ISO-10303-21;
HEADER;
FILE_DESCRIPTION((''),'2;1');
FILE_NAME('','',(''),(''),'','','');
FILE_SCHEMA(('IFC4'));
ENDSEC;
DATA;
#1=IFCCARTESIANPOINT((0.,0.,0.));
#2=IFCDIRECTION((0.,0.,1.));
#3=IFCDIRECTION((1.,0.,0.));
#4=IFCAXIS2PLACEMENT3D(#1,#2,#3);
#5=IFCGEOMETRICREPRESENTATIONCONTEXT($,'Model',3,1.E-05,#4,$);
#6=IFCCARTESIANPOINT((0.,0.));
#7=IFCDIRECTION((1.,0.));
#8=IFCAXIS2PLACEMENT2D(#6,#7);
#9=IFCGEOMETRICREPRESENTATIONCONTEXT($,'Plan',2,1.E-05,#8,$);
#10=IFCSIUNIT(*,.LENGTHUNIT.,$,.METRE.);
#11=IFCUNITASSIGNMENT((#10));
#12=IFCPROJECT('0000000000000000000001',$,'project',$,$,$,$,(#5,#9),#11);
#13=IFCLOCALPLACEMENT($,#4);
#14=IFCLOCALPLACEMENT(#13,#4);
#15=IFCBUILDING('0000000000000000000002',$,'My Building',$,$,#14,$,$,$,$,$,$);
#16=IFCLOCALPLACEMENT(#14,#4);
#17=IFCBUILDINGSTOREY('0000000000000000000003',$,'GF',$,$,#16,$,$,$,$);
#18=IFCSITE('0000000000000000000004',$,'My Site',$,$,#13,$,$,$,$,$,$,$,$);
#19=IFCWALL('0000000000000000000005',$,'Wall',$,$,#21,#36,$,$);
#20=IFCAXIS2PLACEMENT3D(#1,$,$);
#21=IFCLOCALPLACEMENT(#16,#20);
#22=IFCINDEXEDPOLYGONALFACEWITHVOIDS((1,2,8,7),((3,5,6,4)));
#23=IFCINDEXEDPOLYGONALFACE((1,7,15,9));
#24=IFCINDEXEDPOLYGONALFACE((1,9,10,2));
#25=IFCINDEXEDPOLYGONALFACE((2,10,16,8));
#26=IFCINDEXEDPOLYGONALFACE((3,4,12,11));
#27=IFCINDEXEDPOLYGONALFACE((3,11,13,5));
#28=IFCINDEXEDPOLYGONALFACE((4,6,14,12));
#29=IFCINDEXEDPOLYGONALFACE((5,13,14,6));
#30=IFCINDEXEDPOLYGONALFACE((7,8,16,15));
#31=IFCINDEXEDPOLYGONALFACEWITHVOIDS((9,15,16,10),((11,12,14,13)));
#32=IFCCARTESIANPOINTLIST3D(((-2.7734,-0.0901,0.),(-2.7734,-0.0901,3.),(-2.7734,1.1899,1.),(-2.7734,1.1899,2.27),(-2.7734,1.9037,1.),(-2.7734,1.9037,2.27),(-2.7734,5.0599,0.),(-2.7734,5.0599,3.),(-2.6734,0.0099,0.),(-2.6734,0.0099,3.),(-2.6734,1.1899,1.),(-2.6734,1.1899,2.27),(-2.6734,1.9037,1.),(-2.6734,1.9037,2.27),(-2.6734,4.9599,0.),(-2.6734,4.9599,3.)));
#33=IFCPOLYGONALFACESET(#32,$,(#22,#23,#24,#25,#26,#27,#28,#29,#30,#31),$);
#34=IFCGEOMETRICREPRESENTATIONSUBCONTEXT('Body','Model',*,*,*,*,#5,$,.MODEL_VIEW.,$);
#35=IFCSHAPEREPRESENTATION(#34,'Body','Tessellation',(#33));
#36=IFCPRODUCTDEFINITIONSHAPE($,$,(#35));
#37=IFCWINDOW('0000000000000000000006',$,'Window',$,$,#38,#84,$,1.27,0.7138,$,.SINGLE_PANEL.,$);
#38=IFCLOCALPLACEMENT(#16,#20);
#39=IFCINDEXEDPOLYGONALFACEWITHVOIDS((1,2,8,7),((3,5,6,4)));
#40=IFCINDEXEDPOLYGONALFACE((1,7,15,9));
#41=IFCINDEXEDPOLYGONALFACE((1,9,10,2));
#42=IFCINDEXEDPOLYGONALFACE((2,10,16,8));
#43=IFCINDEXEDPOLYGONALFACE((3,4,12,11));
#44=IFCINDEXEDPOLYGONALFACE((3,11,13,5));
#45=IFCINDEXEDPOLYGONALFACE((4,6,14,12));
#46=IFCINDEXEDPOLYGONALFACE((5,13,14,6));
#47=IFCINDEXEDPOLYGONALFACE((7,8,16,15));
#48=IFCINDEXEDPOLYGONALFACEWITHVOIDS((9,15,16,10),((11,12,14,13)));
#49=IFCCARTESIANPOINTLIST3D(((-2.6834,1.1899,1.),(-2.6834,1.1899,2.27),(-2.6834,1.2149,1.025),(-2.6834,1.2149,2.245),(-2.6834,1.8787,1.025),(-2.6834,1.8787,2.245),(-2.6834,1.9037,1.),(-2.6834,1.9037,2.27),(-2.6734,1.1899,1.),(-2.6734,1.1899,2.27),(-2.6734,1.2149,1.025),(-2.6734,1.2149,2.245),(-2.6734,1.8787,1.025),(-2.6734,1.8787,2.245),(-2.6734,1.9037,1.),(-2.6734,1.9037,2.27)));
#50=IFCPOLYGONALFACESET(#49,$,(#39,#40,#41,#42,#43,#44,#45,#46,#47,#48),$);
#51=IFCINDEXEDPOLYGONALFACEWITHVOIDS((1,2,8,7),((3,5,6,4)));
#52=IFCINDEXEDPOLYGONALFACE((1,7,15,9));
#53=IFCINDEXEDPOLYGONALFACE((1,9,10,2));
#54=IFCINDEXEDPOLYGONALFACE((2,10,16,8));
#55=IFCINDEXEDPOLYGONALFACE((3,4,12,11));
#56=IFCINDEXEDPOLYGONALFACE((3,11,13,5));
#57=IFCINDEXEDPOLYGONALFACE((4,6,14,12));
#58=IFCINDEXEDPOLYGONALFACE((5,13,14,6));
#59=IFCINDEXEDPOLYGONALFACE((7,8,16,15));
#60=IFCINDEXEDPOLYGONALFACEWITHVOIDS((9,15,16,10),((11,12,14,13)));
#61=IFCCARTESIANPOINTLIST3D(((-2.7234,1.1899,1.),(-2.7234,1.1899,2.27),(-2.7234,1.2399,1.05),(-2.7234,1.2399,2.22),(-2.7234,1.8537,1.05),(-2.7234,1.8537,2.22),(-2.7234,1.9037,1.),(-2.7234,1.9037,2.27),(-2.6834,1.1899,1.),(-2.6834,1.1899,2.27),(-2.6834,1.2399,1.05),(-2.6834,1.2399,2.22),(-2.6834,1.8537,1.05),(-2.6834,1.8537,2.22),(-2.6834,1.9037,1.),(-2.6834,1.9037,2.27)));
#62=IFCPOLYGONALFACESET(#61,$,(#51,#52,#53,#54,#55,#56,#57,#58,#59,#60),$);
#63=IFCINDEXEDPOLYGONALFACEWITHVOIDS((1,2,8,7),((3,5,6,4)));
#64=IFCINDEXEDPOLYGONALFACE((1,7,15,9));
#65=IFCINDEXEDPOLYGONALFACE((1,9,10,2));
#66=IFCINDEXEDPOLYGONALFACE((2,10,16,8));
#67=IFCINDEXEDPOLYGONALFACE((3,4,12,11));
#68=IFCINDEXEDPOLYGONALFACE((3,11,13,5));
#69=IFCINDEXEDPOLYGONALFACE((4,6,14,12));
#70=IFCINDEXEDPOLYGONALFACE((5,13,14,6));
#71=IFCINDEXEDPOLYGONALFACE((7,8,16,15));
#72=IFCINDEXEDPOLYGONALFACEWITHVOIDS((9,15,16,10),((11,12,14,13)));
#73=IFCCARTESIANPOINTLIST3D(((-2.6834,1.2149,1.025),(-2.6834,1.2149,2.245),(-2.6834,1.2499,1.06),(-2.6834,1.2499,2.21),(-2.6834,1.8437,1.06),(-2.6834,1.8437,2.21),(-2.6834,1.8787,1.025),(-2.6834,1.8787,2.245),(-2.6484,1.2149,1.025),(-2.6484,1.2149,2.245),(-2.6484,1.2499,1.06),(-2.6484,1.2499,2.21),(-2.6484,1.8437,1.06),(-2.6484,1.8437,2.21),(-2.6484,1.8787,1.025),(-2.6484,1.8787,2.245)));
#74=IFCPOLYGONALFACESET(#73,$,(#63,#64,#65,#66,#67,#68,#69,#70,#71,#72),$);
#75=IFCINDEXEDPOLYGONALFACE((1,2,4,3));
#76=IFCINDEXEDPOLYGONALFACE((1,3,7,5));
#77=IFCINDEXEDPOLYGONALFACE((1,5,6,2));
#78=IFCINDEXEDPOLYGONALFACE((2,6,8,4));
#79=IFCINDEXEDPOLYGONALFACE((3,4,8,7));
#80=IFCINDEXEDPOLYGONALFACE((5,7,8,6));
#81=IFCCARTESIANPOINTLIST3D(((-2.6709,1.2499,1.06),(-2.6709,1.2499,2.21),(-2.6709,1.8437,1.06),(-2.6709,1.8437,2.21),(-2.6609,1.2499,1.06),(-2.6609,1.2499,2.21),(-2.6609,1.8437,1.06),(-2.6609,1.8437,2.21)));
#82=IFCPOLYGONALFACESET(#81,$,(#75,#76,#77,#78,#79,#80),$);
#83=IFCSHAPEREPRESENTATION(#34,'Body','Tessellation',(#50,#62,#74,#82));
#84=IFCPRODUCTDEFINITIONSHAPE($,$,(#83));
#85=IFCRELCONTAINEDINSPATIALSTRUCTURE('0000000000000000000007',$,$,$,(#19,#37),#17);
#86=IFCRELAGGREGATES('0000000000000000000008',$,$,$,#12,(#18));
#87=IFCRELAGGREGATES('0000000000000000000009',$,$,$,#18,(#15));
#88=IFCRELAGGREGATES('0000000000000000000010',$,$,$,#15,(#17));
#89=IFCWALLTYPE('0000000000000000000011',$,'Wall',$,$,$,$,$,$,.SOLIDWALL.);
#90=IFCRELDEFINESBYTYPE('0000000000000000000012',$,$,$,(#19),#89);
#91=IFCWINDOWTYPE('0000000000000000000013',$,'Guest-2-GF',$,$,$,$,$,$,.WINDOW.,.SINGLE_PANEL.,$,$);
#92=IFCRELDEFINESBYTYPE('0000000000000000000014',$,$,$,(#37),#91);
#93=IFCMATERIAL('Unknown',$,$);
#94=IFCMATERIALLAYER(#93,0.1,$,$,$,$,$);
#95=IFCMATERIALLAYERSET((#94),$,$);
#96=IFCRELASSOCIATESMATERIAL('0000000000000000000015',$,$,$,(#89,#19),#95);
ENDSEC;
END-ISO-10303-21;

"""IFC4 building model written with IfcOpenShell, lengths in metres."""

from ifc_helpers import new_model, entity, si_unit, frame, origin_with_axes, origin_2d_with_axis, place, context, subcontext, project, spatial, line, indexed_curve, outline, extrude, shape, source, transform, mapped, material, layer, layer_set, layer_usage, type_object, type_shapes, element, fill, save


model = new_model("IFC4")

# Units and contexts
model_context = context("Model", 3, precision=1e-05, world=origin_with_axes())
plan_context = context("Plan", 2, precision=1e-05, world=origin_2d_with_axis())
body_context_1 = subcontext(model_context, "Body", "Model", "MODEL_VIEW")
body_context_2 = subcontext(plan_context, "Body", "Plan", "PLAN_VIEW")
ifc_project = project(units=[si_unit("LENGTHUNIT", "METRE")], contexts=[model_context, plan_context])

# Site, building, storey
site_placement = place(None, origin_with_axes())
site = spatial("IfcSite", under=ifc_project, at=site_placement, Name="My Site")
building_placement = place(site_placement, origin_with_axes())
building = spatial("IfcBuilding", under=site, at=building_placement, Name="My Building")
storey_placement = place(building_placement, origin_with_axes())
storey = spatial("IfcBuildingStorey", under=building, at=storey_placement, Name="GF")

# Shared definitions
ifc_material = material(Name="Unknown")

# Shared definitions
ifc_layer_1 = layer(ifc_material, 0.1)
ifc_layer_set_1 = layer_set([ifc_layer_1])
wall_type = type_object("IfcWallType", Name="Wall", PredefinedType="SOLIDWALL", material=ifc_layer_set_1)

# Wall, opening, window
ifc_layer_usage_1 = layer_usage(ifc_layer_set_1, "AXIS2", "POSITIVE", 0.0)
wall_1_placement = place(storey_placement, frame((-2.7734, 5.0599, 0.0), z_axis=(0.0, 0.0, 1.0), x_axis=(0.0, -1.0, 0.0)))
wall_1 = element("IfcWall", 1, at=wall_1_placement, inside=storey, type_object=wall_type, material=ifc_layer_usage_1, Name="Wall", context=body_context_1, shape_type="SweptSolid", body=[
    extrude(outline(indexed_curve([(0.0, 0.0), (0.1, 0.1), (5.05, 0.1), (5.15, 0.0)], segments=[line(1, 2, 3, 4, 1)])), origin_with_axes(), (0.0, 0.0, 1.0), 3.0),
])
shared_shape_1 = source(origin_with_axes(), body_context_1, "Body", "SweptSolid", [
    extrude(outline(indexed_curve([(0.0, 0.0), (0.7138, 0.0), (0.7138, 1.27), (0.0, 1.27)], segments=[line(1, 2, 3, 4, 1)])), frame((0.0, -0.6, 0.0), z_axis=(0.0, -1.0, 0.0), x_axis=(1.0, 0.0, 0.0)), (0.0, 0.0, -1.0), 1.2),
])
opening_1_placement = place(wall_1_placement, frame((3.1562, 0.0, 1.0), z_axis=(0.0, 0.0, 1.0), x_axis=(1.0, 0.0, 0.0)))
opening_1 = element("IfcOpeningElement", 2, at=opening_1_placement, cuts=wall_1, PredefinedType="OPENING", context=body_context_1, shape_type="MappedRepresentation", body=[
    mapped(shared_shape_1, transform((0.0, 0.0, 0.0), x_axis=(1.0, 0.0, 0.0), y_axis=(0.0, 1.0, 0.0), z_axis=(0.0, 0.0, 1.0), scale=1.0)),
])
window_type_1 = type_object("IfcWindowType", Name="Guest-2-GF", PartitioningType="SINGLE_PANEL", PredefinedType="WINDOW")
shared_shape_2 = source(origin_with_axes(), body_context_1, "Body", "SweptSolid", [
    extrude(outline(indexed_curve([(0.0, 0.0), (0.7138, 0.0), (0.7138, 1.27), (0.0, 1.27)], segments=[line(1, 2, 3, 4, 1)]), holes=[indexed_curve([(0.025, 0.025), (0.6888, 0.025), (0.6888, 1.245), (0.025, 1.245)], segments=[line(1, 2, 3, 4, 1)])]), frame((0.0, 0.09, 0.0), z_axis=(0.0, -1.0, 0.0), x_axis=(1.0, 0.0, 0.0)), (0.0, 0.0, -1.0), 0.01),
    extrude(outline(indexed_curve([(0.0, 0.0), (0.7138, 0.0), (0.7138, 1.27), (0.0, 1.27)], segments=[line(1, 2, 3, 4, 1)]), holes=[indexed_curve([(0.05, 0.05), (0.6638, 0.05), (0.6638, 1.22), (0.05, 1.22)], segments=[line(1, 2, 3, 4, 1)])]), frame((0.0, 0.05, 0.0), z_axis=(0.0, -1.0, 0.0), x_axis=(1.0, 0.0, 0.0)), (0.0, 0.0, -1.0), 0.04),
    extrude(outline(indexed_curve([(0.0, 0.0), (0.6638, 0.0), (0.6638, 1.22), (0.0, 1.22)], segments=[line(1, 2, 3, 4, 1)]), holes=[indexed_curve([(0.035, 0.035), (0.6288, 0.035), (0.6288, 1.185), (0.035, 1.185)], segments=[line(1, 2, 3, 4, 1)])]), frame((0.025, 0.09, 0.025), z_axis=(0.0, -1.0, 0.0), x_axis=(1.0, 0.0, 0.0)), (0.0, 0.0, -1.0), 0.035),
    extrude(outline(indexed_curve([(0.035, 0.035), (0.6288, 0.035), (0.6288, 1.185), (0.035, 1.185)], segments=[line(1, 2, 3, 4, 1)])), frame((0.025, 0.1025, 0.025), z_axis=(0.0, -1.0, 0.0), x_axis=(1.0, 0.0, 0.0)), (0.0, 0.0, -1.0), 0.01),
])
shared_shape_3 = source(origin_with_axes(), body_context_2, "Body", "Curve2D", [
    entity("IfcIndexedPolyCurve", entity("IfcCartesianPointList2D", [[0.05, 0.05], [0.6638, 0.05]])),
    entity("IfcIndexedPolyCurve", entity("IfcCartesianPointList2D", [[0.0, 0.1], [0.025, 0.1], [0.025, 0.09], [0.05, 0.09], [0.05, 0.05], [0.0, 0.05]]), [entity("IfcLineIndex", [1, 2, 3, 4, 5, 6, 1])]),
    entity("IfcIndexedPolyCurve", entity("IfcCartesianPointList2D", [[0.7138, 0.1], [0.6888, 0.1], [0.6888, 0.09], [0.6638, 0.09], [0.6638, 0.05], [0.7138, 0.05]]), [entity("IfcLineIndex", [1, 2, 3, 4, 5, 6, 1])]),
    entity("IfcIndexedPolyCurve", entity("IfcCartesianPointList2D", [[0.025, 0.09], [0.06, 0.09], [0.06, 0.125], [0.025, 0.125]]), [entity("IfcLineIndex", [1, 2, 3, 4, 1])]),
    entity("IfcIndexedPolyCurve", entity("IfcCartesianPointList2D", [[0.6888, 0.09], [0.6538, 0.09], [0.6538, 0.125], [0.6888, 0.125]]), [entity("IfcLineIndex", [1, 2, 3, 4, 1])]),
    entity("IfcIndexedPolyCurve", entity("IfcCartesianPointList2D", [[0.06, 0.09], [0.6538, 0.09]])),
    entity("IfcIndexedPolyCurve", entity("IfcCartesianPointList2D", [[0.06, 0.125], [0.6538, 0.125]])),
    entity("IfcIndexedPolyCurve", entity("IfcCartesianPointList2D", [[0.06, 0.1075], [0.6538, 0.1075]])),
])
type_shapes(window_type_1, [shared_shape_2, shared_shape_3])
window_1_placement = place(opening_1_placement, frame((0.0, 0.0, 0.0), z_axis=(0.0, 0.0, 1.0), x_axis=(1.0, 0.0, 0.0)))
window_1 = element("IfcWindow", 3, at=window_1_placement, inside=storey, type_object=window_type_1, Name="Window", OverallHeight=1.27, OverallWidth=0.7138, PartitioningType="SINGLE_PANEL", shapes=[
    shape(body_context_1, "Body", "MappedRepresentation", [mapped(shared_shape_2, transform((0.0, 0.0, 0.0), x_axis=(1.0, 0.0, 0.0), y_axis=(0.0, 1.0, 0.0), z_axis=(0.0, 0.0, 1.0), scale=1.0))]),
    shape(body_context_2, "Body", "MappedRepresentation", [mapped(shared_shape_3, transform((0.0, 0.0, 0.0), x_axis=(1.0, 0.0, 0.0), y_axis=(0.0, 1.0, 0.0), z_axis=(0.0, 0.0, 1.0), scale=1.0))]),
])
fill(opening_1, window_1)

save(model, "model.ifc")
